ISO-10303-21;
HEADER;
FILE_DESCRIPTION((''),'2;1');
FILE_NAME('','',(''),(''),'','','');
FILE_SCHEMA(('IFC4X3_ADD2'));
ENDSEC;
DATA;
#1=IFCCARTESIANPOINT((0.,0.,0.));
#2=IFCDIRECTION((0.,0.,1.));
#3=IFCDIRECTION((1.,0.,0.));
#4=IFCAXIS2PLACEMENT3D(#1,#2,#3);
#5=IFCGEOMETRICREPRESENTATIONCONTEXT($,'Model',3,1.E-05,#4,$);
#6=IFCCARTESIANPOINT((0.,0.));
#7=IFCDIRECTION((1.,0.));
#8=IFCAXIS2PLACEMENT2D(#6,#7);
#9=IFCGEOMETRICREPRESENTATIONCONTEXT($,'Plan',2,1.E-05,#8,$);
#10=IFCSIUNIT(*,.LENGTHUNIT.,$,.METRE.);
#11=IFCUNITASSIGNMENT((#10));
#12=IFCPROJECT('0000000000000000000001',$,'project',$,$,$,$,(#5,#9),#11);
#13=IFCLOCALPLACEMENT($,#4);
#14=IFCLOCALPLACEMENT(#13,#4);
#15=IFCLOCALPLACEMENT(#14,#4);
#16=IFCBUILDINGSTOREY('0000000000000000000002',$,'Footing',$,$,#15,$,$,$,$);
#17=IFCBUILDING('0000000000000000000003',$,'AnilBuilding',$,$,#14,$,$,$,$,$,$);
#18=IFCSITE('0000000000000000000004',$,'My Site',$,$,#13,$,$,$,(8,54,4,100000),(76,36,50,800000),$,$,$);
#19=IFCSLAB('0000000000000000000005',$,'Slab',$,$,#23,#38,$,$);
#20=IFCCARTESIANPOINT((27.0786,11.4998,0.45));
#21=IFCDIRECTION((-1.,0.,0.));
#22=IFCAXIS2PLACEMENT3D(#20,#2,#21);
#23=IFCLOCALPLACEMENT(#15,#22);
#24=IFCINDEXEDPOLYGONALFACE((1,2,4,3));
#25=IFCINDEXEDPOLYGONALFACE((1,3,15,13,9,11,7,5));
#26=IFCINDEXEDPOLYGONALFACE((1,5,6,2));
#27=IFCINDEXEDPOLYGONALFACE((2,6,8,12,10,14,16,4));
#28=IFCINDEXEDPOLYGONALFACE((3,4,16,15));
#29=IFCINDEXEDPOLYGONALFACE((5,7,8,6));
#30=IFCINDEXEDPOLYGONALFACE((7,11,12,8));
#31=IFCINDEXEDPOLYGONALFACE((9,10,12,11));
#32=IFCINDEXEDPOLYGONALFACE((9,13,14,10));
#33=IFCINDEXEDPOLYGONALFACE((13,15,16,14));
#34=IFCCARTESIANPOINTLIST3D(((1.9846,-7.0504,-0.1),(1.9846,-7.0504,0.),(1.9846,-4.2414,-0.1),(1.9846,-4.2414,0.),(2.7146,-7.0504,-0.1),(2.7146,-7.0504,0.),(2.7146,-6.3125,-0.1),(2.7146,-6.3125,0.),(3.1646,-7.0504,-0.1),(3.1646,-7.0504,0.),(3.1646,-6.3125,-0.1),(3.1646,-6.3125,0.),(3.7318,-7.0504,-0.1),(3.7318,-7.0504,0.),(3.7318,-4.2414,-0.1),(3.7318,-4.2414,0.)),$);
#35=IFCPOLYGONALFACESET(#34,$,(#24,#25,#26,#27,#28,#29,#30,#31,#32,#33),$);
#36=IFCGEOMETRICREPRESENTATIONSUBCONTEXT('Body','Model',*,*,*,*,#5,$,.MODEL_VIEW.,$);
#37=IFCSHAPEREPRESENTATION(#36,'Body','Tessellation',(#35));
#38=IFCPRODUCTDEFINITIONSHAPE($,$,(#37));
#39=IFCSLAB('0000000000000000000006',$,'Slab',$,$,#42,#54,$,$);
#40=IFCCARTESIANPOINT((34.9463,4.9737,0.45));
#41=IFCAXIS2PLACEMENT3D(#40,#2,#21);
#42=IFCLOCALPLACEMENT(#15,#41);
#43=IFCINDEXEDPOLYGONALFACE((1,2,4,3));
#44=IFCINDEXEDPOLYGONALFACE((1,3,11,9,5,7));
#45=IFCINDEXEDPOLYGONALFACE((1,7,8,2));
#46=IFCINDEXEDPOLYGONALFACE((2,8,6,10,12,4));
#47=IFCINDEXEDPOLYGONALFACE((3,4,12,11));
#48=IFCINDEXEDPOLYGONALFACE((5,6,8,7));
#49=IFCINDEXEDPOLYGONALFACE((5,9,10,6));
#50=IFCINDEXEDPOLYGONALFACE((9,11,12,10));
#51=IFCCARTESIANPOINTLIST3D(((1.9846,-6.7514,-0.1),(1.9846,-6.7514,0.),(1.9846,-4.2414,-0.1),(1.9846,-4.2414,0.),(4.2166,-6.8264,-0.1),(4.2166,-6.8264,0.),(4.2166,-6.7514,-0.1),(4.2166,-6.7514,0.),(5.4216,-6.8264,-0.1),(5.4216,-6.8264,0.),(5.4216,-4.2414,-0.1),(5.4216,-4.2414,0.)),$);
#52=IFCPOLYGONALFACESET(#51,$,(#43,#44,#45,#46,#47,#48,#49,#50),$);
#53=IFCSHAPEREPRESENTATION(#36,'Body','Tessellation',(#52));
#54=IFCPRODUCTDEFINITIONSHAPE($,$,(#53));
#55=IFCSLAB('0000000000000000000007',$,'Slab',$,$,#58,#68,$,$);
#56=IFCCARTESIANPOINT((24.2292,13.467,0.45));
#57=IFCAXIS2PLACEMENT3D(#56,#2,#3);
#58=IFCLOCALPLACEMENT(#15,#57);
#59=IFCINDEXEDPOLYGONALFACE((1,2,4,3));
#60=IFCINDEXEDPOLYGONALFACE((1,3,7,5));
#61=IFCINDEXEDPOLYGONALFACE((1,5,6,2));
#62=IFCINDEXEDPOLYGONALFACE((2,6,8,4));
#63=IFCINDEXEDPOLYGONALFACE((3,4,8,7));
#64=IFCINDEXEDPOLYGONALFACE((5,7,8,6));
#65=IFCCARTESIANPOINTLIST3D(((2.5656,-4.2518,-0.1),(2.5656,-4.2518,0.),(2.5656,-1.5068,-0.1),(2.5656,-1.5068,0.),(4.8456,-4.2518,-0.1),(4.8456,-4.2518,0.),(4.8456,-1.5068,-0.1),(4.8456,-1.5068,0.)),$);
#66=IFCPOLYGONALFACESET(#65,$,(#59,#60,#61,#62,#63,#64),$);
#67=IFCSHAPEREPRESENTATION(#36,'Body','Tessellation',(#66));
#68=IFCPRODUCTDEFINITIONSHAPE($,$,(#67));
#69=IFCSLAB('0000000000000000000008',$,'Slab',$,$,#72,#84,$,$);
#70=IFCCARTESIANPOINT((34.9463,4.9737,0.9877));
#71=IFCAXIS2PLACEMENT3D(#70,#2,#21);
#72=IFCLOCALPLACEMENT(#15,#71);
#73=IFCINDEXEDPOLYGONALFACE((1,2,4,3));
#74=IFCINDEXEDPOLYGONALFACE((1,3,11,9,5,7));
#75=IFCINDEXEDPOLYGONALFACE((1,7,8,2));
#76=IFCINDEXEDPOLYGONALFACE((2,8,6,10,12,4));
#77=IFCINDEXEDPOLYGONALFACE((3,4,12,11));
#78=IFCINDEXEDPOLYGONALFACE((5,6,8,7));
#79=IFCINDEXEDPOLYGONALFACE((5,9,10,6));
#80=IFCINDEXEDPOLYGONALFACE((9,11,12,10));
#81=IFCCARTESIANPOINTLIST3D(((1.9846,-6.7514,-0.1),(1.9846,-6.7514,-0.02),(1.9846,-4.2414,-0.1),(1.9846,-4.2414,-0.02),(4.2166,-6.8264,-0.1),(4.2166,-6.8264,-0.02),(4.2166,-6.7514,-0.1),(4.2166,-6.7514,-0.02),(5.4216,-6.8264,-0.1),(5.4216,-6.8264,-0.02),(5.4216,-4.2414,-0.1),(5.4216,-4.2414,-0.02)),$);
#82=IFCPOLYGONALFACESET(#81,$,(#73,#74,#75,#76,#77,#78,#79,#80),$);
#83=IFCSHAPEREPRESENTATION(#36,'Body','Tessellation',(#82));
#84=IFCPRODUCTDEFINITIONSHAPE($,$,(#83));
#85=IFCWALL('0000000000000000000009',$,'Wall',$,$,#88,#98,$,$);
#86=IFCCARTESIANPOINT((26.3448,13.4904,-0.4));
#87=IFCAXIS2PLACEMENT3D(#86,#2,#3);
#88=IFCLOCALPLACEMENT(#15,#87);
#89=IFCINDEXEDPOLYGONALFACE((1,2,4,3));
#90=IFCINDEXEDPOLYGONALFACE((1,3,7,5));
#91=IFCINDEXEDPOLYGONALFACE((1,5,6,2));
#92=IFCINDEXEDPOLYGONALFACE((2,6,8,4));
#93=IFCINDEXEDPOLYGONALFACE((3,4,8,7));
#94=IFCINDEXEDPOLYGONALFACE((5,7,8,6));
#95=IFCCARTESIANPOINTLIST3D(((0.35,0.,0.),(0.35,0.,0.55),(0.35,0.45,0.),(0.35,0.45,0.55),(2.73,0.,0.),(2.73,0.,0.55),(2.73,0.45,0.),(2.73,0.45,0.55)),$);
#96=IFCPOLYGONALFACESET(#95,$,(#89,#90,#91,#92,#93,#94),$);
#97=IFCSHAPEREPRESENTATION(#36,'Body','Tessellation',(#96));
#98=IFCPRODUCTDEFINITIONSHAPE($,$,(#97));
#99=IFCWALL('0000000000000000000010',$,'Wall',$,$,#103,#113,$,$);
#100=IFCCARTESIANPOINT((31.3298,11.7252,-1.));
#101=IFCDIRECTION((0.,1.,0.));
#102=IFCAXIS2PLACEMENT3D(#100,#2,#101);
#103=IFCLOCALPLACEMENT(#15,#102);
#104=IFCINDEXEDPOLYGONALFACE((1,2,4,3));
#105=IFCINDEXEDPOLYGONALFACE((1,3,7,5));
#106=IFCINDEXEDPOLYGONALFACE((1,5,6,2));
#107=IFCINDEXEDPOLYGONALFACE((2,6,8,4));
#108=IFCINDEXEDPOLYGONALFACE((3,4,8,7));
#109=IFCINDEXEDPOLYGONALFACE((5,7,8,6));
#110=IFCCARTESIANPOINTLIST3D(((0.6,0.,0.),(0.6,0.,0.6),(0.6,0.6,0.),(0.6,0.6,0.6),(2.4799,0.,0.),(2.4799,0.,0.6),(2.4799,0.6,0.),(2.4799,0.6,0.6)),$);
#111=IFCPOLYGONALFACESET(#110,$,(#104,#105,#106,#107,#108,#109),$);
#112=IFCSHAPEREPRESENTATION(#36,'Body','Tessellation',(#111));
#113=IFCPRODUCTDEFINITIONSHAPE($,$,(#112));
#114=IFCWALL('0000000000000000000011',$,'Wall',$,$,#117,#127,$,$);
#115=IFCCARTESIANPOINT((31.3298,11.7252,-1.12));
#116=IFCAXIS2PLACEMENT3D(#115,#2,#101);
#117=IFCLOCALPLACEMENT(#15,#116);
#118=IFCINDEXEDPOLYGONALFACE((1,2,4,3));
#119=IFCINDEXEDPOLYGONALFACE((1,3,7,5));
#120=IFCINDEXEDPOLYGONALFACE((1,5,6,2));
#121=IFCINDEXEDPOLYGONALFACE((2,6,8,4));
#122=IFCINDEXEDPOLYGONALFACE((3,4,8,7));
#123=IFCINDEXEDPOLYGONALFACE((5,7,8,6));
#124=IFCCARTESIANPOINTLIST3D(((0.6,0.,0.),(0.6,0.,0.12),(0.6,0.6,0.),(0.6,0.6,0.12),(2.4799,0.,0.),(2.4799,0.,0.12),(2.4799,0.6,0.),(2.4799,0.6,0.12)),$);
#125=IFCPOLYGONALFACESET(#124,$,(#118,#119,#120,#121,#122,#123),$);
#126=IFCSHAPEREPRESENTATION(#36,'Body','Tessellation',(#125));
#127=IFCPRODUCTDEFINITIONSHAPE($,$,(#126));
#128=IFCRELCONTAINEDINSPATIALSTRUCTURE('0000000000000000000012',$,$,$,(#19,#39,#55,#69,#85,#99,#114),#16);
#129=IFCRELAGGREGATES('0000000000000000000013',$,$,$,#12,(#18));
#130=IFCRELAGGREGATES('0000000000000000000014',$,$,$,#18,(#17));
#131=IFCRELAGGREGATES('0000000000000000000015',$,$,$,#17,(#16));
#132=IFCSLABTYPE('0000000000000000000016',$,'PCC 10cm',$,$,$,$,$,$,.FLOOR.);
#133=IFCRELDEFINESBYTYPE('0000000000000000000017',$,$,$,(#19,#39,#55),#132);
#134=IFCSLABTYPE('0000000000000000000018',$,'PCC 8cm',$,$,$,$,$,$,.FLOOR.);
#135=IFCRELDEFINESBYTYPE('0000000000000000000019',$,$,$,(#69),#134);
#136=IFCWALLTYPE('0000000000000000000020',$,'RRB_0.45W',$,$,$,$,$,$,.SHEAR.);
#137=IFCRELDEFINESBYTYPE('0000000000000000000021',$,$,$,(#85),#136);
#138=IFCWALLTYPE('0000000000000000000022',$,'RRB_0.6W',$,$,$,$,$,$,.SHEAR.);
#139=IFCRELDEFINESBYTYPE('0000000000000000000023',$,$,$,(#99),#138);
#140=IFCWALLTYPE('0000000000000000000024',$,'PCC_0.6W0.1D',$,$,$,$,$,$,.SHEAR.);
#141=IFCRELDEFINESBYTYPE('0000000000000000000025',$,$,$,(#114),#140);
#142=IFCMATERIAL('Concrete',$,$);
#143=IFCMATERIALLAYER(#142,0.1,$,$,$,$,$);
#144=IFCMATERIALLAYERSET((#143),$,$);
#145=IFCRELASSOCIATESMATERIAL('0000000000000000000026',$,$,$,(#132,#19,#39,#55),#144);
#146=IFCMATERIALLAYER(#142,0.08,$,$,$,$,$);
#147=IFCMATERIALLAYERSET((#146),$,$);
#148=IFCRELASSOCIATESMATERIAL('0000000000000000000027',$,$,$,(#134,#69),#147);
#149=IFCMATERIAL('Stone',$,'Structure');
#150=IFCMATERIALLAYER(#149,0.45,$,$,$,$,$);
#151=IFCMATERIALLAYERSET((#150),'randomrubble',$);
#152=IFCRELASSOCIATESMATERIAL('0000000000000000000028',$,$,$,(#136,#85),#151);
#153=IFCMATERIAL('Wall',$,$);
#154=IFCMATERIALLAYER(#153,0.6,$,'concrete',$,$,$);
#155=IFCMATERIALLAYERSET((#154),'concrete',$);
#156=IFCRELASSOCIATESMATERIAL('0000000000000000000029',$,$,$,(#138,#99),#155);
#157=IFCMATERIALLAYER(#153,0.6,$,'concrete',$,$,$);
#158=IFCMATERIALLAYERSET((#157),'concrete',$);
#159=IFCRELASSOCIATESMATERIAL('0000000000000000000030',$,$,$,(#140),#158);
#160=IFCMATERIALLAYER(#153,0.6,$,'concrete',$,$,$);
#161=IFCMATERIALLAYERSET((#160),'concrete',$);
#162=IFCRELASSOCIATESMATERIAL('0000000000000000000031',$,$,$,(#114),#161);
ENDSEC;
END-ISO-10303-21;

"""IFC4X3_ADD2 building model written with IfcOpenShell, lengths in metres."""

from ifc_helpers import new_model, si_unit, frame, origin_with_axes, origin_2d_with_axis, place, context, subcontext, project, spatial, line, indexed_curve, outline, extrude, material, layer, layer_set, layer_usage, type_object, element, save


model = new_model("IFC4X3_ADD2")

# Units and contexts
model_context = context("Model", 3, precision=1e-05, world=origin_with_axes())
plan_context = context("Plan", 2, precision=1e-05, world=origin_2d_with_axis())
body_context = subcontext(model_context, "Body", "Model", "MODEL_VIEW")
ifc_project = project(units=[si_unit("LENGTHUNIT", "METRE")], contexts=[model_context, plan_context])

# Site, building, storey
site_placement = place(None, origin_with_axes())
site = spatial("IfcSite", under=ifc_project, at=site_placement, Name="My Site", RefLatitude=(8, 54, 4, 100000), RefLongitude=(76, 36, 50, 800000))
building_placement = place(site_placement, origin_with_axes())
building = spatial("IfcBuilding", under=site, at=building_placement, Name="AnilBuilding")
storey_placement = place(building_placement, origin_with_axes())
storey = spatial("IfcBuildingStorey", under=building, at=storey_placement, Name="Footing")

# Shared definitions
ifc_material_1 = material(Name="Wall")
ifc_material_2 = material(Name="Stone", Category="Structure")
ifc_material_3 = material(Name="Concrete")

# Slabs
ifc_layer_1 = layer(ifc_material_3, 0.1)
ifc_layer_set_1 = layer_set([ifc_layer_1])
ifc_layer_usage_1 = layer_usage(ifc_layer_set_1, "AXIS3", "POSITIVE", -0.1)
slab_type_1 = type_object("IfcSlabType", Name="PCC 10cm", PredefinedType="FLOOR", material=ifc_layer_set_1)
slab_1_placement = place(storey_placement, frame((27.0786, 11.4998, 0.45), z_axis=(0.0, 0.0, 1.0), x_axis=(-1.0, 0.0, 0.0)))
element("IfcSlab", 1, at=slab_1_placement, inside=storey, type_object=slab_type_1, material=ifc_layer_usage_1, Name="Slab", context=body_context, shape_type="SweptSolid", body=[
    extrude(outline(indexed_curve([(1.9846, -4.2414), (1.9846, -7.0504), (2.7146, -7.0504), (2.7146, -6.3125), (3.1646, -6.3125), (3.1646, -7.0504), (3.7318, -7.0504), (3.7318, -4.2414), (1.9846, -4.2414)])), frame((0.0, 0.0, -0.1), z_axis=(0.0, 0.0, 1.0), x_axis=(1.0, 0.0, 0.0)), (0.0, 0.0, 1.0), 0.1),
])
ifc_layer_usage_2 = layer_usage(ifc_layer_set_1, "AXIS3", "POSITIVE", -0.1)
slab_2_placement = place(storey_placement, frame((34.9463, 4.9737, 0.45), z_axis=(0.0, 0.0, 1.0), x_axis=(-1.0, 0.0, 0.0)))
element("IfcSlab", 2, at=slab_2_placement, inside=storey, type_object=slab_type_1, material=ifc_layer_usage_2, Name="Slab", context=body_context, shape_type="SweptSolid", body=[
    extrude(outline(indexed_curve([(4.2166, -6.8264), (4.2166, -6.7514), (1.9846, -6.7514), (1.9846, -4.2414), (5.4216, -4.2414), (5.4216, -6.8264), (4.2166, -6.8264)])), frame((0.0, 0.0, -0.1), z_axis=(0.0, 0.0, 1.0), x_axis=(1.0, 0.0, 0.0)), (0.0, 0.0, 1.0), 0.1),
])
ifc_layer_usage_3 = layer_usage(ifc_layer_set_1, "AXIS3", "POSITIVE", -0.1)
slab_3_placement = place(storey_placement, frame((24.2292, 13.467, 0.45), z_axis=(0.0, 0.0, 1.0), x_axis=(1.0, 0.0, 0.0)))
element("IfcSlab", 3, at=slab_3_placement, inside=storey, type_object=slab_type_1, material=ifc_layer_usage_3, Name="Slab", context=body_context, shape_type="SweptSolid", body=[
    extrude(outline(indexed_curve([(2.5656, -4.2518), (4.8456, -4.2518), (4.8456, -1.5068), (2.5656, -1.5068), (2.5656, -4.2518)])), frame((0.0, 0.0, -0.1), z_axis=(0.0, 0.0, 1.0), x_axis=(1.0, 0.0, 0.0)), (0.0, 0.0, 1.0), 0.1),
])
ifc_layer_2 = layer(ifc_material_3, 0.08)
ifc_layer_set_2 = layer_set([ifc_layer_2])
ifc_layer_usage_4 = layer_usage(ifc_layer_set_2, "AXIS3", "POSITIVE", -0.1)
slab_type_2 = type_object("IfcSlabType", Name="PCC 8cm", PredefinedType="FLOOR", material=ifc_layer_set_2)
slab_4_placement = place(storey_placement, frame((34.9463, 4.9737, 0.9877), z_axis=(0.0, 0.0, 1.0), x_axis=(-1.0, 0.0, 0.0)))
element("IfcSlab", 4, at=slab_4_placement, inside=storey, type_object=slab_type_2, material=ifc_layer_usage_4, Name="Slab", context=body_context, shape_type="SweptSolid", body=[
    extrude(outline(indexed_curve([(4.2166, -6.8264), (4.2166, -6.7514), (1.9846, -6.7514), (1.9846, -4.2414), (5.4216, -4.2414), (5.4216, -6.8264), (4.2166, -6.8264)])), frame((0.0, 0.0, -0.1), z_axis=(0.0, 0.0, 1.0), x_axis=(1.0, 0.0, 0.0)), (0.0, 0.0, 1.0), 0.08),
])

# Walls
ifc_layer_3 = layer(ifc_material_2, 0.45)
ifc_layer_set_3 = layer_set([ifc_layer_3], Name="randomrubble")
wall_type_1 = type_object("IfcWallType", Name="RRB_0.45W", PredefinedType="SHEAR", material=ifc_layer_set_3)
ifc_layer_usage_5 = layer_usage(ifc_layer_set_3, "AXIS2", "POSITIVE", 0.0)
wall_1_placement = place(storey_placement, frame((26.3448, 13.4904, -0.4), z_axis=(0.0, 0.0, 1.0), x_axis=(1.0, 0.0, 0.0)))
element("IfcWall", 5, at=wall_1_placement, inside=storey, type_object=wall_type_1, material=ifc_layer_usage_5, Name="Wall", context=body_context, shape_type="SweptSolid", body=[
    extrude(outline(indexed_curve([(0.35, 0.0), (0.35, 0.45), (2.73, 0.45), (2.73, 0.0)], segments=[line(1, 2, 3, 4, 1)])), origin_with_axes(), (0.0, 0.0, 1.0), 0.55),
])
ifc_layer_4 = layer(ifc_material_1, 0.6, Name="concrete")
ifc_layer_set_4 = layer_set([ifc_layer_4], Name="concrete")
wall_type_2 = type_object("IfcWallType", Name="RRB_0.6W", PredefinedType="SHEAR", material=ifc_layer_set_4)
ifc_layer_usage_6 = layer_usage(ifc_layer_set_4, "AXIS2", "POSITIVE", 0.0)
wall_2_placement = place(storey_placement, frame((31.3298, 11.7252, -1.0), z_axis=(0.0, 0.0, 1.0), x_axis=(0.0, 1.0, 0.0)))
element("IfcWall", 6, at=wall_2_placement, inside=storey, type_object=wall_type_2, material=ifc_layer_usage_6, Name="Wall", context=body_context, shape_type="SweptSolid", body=[
    extrude(outline(indexed_curve([(0.6, 0.0), (0.6, 0.6), (2.4799, 0.6), (2.4799, 0.0)], segments=[line(1, 2, 3, 4, 1)])), origin_with_axes(), (0.0, 0.0, 1.0), 0.6),
])
ifc_layer_5 = layer(ifc_material_1, 0.6, Name="concrete")
ifc_layer_set_5 = layer_set([ifc_layer_5], Name="concrete")
wall_type_3 = type_object("IfcWallType", Name="PCC_0.6W0.1D", PredefinedType="SHEAR", material=ifc_layer_set_5)
ifc_layer_6 = layer(ifc_material_1, 0.6, Name="concrete")
ifc_layer_set_6 = layer_set([ifc_layer_6], Name="concrete")
ifc_layer_usage_7 = layer_usage(ifc_layer_set_6, "AXIS2", "POSITIVE", 0.0)
wall_3_placement = place(storey_placement, frame((31.3298, 11.7252, -1.12), z_axis=(0.0, 0.0, 1.0), x_axis=(0.0, 1.0, 0.0)))
element("IfcWall", 7, at=wall_3_placement, inside=storey, type_object=wall_type_3, material=ifc_layer_usage_7, Name="Wall", context=body_context, shape_type="SweptSolid", body=[
    extrude(outline(indexed_curve([(0.6, 0.0), (0.6, 0.6), (2.4799, 0.6), (2.4799, 0.0)], segments=[line(1, 2, 3, 4, 1)])), origin_with_axes(), (0.0, 0.0, 1.0), 0.12),
])

save(model, "model.ifc")
